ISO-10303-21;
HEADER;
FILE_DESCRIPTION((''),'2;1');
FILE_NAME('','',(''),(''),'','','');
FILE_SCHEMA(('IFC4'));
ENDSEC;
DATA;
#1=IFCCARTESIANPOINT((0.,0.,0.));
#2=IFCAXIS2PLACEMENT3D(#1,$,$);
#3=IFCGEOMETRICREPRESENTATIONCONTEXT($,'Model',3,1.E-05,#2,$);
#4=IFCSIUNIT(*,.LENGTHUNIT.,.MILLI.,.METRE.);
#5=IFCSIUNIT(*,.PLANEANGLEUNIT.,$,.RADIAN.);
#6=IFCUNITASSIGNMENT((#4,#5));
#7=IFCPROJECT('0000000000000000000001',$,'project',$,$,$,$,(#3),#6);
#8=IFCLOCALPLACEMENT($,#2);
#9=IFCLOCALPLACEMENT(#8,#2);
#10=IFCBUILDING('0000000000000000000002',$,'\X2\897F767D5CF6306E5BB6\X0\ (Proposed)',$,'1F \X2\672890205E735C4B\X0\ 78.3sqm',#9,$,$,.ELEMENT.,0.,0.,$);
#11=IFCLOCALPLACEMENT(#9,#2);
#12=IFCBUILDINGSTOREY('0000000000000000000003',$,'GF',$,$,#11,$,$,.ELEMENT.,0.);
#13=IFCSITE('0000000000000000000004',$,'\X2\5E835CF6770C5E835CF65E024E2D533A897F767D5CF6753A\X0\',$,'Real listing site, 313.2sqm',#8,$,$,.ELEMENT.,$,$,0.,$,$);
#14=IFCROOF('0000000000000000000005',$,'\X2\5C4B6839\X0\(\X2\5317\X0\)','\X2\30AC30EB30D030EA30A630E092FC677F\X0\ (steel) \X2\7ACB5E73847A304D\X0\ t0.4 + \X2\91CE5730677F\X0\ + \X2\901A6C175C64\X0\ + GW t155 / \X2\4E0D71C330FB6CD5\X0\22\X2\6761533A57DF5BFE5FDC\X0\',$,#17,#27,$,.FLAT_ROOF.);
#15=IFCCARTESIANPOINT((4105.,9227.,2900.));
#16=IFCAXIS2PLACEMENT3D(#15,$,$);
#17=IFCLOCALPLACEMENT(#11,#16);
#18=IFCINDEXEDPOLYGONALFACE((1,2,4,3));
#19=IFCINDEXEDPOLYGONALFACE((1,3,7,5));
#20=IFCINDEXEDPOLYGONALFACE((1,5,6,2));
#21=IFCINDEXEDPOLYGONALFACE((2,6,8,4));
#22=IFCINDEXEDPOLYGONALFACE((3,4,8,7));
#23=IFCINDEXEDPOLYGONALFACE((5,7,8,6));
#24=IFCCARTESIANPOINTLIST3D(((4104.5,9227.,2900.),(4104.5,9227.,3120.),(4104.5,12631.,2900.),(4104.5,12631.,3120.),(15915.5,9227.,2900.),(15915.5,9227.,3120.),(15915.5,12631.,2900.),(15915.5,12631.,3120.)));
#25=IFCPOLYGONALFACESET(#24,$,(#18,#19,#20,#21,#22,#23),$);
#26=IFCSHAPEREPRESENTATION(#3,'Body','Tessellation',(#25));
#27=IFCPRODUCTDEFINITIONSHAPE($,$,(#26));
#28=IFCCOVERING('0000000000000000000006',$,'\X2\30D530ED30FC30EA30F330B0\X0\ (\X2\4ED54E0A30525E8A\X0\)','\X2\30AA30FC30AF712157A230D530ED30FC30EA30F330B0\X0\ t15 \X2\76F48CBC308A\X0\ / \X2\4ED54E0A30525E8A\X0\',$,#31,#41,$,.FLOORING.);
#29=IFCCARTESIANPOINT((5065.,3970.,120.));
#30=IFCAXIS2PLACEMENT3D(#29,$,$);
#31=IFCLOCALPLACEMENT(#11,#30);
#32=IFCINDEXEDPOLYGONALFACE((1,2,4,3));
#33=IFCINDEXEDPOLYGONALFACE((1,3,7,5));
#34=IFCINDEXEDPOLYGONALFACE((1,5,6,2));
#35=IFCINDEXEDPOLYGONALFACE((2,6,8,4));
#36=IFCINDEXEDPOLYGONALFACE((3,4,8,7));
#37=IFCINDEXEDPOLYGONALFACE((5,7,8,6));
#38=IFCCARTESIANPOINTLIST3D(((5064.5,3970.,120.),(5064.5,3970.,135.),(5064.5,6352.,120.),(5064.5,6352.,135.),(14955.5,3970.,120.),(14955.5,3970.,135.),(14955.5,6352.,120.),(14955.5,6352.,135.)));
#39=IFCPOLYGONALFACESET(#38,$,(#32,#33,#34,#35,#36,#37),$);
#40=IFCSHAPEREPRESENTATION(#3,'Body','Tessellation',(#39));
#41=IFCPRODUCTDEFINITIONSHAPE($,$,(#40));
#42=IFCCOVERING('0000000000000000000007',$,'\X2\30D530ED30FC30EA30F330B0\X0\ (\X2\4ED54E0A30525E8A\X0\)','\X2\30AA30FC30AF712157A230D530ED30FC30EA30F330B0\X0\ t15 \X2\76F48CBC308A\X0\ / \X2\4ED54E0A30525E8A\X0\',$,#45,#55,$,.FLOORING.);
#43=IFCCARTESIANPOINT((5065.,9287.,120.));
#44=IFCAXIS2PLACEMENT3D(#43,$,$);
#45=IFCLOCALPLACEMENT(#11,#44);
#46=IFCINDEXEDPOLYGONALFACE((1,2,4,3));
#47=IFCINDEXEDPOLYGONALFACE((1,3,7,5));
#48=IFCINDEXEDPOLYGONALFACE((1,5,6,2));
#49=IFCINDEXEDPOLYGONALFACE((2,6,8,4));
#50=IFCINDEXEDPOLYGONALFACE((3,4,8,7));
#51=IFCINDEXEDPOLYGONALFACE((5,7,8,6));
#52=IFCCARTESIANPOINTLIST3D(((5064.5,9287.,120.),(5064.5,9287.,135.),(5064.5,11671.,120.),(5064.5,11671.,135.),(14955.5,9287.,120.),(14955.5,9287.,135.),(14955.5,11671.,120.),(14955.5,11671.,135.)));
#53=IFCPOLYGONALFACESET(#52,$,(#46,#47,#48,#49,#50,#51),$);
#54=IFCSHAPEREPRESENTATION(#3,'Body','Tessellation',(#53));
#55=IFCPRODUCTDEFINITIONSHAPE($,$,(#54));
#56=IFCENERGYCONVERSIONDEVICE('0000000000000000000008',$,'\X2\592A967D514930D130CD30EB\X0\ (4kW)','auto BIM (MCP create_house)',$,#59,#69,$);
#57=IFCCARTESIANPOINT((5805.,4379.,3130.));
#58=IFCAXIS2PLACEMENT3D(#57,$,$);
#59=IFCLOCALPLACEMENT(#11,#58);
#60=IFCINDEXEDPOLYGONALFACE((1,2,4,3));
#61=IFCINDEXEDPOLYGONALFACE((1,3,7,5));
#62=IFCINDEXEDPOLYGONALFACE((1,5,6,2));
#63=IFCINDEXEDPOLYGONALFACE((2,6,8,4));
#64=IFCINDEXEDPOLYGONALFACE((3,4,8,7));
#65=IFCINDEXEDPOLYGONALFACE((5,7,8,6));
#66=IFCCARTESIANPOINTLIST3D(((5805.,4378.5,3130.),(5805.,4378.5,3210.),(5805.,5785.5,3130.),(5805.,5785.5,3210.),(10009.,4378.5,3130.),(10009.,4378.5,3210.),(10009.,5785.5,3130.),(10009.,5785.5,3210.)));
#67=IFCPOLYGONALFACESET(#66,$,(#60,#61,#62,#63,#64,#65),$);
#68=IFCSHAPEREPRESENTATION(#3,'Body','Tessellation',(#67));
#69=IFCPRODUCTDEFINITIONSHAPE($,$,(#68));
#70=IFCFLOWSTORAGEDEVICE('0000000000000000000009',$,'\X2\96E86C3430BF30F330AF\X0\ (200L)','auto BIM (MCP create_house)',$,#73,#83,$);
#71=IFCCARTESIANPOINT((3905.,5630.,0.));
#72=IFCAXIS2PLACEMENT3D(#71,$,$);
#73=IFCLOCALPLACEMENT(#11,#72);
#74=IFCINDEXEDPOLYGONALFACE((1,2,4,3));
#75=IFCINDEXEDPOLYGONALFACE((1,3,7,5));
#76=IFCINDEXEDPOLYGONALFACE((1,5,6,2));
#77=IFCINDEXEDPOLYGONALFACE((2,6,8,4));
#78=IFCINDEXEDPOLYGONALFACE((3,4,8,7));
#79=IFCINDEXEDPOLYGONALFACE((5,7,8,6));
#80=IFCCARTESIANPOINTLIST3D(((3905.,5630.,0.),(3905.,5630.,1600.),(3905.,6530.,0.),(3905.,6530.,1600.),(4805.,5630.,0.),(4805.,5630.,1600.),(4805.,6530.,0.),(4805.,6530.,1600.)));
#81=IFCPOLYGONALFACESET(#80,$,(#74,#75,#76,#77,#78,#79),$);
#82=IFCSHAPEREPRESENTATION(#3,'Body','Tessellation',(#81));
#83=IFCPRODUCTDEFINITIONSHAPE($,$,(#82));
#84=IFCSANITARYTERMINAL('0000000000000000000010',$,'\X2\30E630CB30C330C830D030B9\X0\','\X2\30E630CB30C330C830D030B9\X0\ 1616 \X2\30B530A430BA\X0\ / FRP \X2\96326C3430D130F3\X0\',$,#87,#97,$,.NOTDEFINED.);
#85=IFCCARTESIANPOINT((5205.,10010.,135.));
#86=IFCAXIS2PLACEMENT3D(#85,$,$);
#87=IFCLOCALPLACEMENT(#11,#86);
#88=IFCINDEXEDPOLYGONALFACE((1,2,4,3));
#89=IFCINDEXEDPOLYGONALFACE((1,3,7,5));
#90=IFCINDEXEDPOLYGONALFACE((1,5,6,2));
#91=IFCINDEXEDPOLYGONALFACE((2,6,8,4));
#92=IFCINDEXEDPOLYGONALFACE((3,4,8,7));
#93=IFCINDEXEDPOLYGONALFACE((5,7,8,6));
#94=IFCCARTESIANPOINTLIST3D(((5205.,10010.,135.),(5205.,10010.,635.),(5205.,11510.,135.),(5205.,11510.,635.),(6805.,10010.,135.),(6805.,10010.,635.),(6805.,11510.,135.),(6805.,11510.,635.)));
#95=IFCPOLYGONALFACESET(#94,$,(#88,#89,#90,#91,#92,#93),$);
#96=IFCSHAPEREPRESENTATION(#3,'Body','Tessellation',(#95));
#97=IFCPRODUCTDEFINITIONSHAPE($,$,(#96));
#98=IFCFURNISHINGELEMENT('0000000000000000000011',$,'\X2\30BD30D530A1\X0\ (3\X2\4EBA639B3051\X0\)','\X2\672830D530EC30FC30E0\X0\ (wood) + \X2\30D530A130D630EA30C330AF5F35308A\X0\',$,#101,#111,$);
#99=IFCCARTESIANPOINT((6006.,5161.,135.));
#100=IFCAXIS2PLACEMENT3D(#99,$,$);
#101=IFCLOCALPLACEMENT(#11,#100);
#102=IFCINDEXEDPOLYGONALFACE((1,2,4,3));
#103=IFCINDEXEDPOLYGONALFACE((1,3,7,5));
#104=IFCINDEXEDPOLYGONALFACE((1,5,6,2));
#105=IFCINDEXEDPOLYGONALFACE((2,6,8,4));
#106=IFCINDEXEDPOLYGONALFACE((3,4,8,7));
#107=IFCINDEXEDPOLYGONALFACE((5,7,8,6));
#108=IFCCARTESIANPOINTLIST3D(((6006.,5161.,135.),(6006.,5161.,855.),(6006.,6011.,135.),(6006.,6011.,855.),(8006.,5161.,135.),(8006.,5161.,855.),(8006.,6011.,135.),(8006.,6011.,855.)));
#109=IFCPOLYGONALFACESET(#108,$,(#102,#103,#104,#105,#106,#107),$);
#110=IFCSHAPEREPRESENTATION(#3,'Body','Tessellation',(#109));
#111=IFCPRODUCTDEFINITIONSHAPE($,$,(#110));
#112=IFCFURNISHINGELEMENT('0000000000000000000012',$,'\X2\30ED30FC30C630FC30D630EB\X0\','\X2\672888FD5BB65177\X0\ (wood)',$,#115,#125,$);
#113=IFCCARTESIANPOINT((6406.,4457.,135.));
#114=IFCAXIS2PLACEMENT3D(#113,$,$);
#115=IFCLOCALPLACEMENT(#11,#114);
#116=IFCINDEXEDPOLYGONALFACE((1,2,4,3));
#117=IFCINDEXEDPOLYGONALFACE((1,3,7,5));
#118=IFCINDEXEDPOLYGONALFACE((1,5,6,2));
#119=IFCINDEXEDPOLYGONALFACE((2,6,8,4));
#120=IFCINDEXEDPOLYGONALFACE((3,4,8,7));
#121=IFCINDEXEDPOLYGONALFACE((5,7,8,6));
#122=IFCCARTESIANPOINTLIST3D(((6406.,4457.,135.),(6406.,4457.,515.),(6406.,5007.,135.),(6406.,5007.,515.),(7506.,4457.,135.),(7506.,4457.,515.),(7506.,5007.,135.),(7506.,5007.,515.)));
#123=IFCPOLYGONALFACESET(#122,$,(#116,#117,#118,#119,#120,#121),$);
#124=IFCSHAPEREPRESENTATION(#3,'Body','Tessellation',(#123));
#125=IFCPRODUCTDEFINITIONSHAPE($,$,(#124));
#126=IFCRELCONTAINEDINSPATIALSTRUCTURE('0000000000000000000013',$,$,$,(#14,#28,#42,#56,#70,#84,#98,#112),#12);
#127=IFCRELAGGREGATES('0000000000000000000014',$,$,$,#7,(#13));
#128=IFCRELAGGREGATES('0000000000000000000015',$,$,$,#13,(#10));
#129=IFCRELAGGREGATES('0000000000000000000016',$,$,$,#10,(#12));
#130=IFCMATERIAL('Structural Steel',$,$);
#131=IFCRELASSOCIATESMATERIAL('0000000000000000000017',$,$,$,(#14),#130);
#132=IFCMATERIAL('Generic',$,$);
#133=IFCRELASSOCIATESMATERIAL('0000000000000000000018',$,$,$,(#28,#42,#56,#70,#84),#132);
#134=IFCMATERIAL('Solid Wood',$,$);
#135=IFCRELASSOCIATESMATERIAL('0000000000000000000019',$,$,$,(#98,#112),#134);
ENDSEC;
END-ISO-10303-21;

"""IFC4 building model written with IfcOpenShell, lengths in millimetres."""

from ifc_helpers import new_model, si_unit, frame, frame_2d, origin, place, context, project, spatial, rectangle, extrude, material, element, save


model = new_model("IFC4")

# Units and contexts
model_context = context("Model", 3, precision=1e-05, world=origin())
ifc_project = project(units=[si_unit("LENGTHUNIT", "METRE", prefix="MILLI"), si_unit("PLANEANGLEUNIT", "RADIAN")], contexts=[model_context])

# Site, building, storey
site_placement = place(None, origin())
site = spatial("IfcSite", under=ifc_project, at=site_placement, Name="広島県広島市中区西白島町", ObjectType="Real listing site, 313.2sqm", CompositionType="ELEMENT", RefElevation=0.0)
building_placement = place(site_placement, origin())
building = spatial("IfcBuilding", under=site, at=building_placement, Name="西白島の家 (Proposed)", ObjectType="1F 木造平屋 78.3sqm", CompositionType="ELEMENT", ElevationOfRefHeight=0.0, ElevationOfTerrain=0.0)
storey_placement = place(building_placement, origin())
storey = spatial("IfcBuildingStorey", under=building, at=storey_placement, Name="GF", CompositionType="ELEMENT", Elevation=0.0)

# Shared definitions
ifc_material_1 = material(Name="Solid Wood")

# Roof
ifc_material_2 = material(Name="Structural Steel")
roof_1_placement = place(storey_placement, frame((4105.0, 9227.0, 2900.0)))
element("IfcRoof", 1, at=roof_1_placement, inside=storey, material=ifc_material_2, Name="屋根(北)", Description="ガルバリウム鋼板 (steel) 立平葺き t0.4 + 野地板 + 通気層 + GW t155 / 不燃・法22条区域対応", PredefinedType="FLAT_ROOF", context=model_context, shape_type="SweptSolid", body=[
    extrude(rectangle(XDim=11811.0, YDim=3404.0, at=frame_2d((5905.0, 1702.0))), frame((4105.0, 9227.0, 2900.0)), (0.0, 0.0, 1.0), 220.0),
])

# Coverings
ifc_material_3 = material(Name="Generic")
covering_1_placement = place(storey_placement, frame((5065.0, 3970.0, 120.0)))
element("IfcCovering", 2, at=covering_1_placement, inside=storey, material=ifc_material_3, Name="フローリング (仕上げ床)", Description="オーク無垢フローリング t15 直貼り / 仕上げ床", PredefinedType="FLOORING", context=model_context, shape_type="SweptSolid", body=[
    extrude(rectangle(XDim=9891.0, YDim=2382.0, at=frame_2d((4945.0, 1191.0))), frame((5065.0, 3970.0, 120.0)), (0.0, 0.0, 1.0), 15.0),
])
covering_2_placement = place(storey_placement, frame((5065.0, 9287.0, 120.0)))
element("IfcCovering", 3, at=covering_2_placement, inside=storey, material=ifc_material_3, Name="フローリング (仕上げ床)", Description="オーク無垢フローリング t15 直貼り / 仕上げ床", PredefinedType="FLOORING", context=model_context, shape_type="SweptSolid", body=[
    extrude(rectangle(XDim=9891.0, YDim=2384.0, at=frame_2d((4945.0, 1192.0))), frame((5065.0, 9287.0, 120.0)), (0.0, 0.0, 1.0), 15.0),
])

# Energy conversion device
energy_conversion_device_placement = place(storey_placement, frame((5805.0, 4379.0, 3130.0)))
element("IfcEnergyConversionDevice", 4, at=energy_conversion_device_placement, inside=storey, material=ifc_material_3, Name="太陽光パネル (4kW)", Description="auto BIM (MCP create_house)", context=model_context, shape_type="SweptSolid", body=[
    extrude(rectangle(XDim=4204.0, YDim=1407.0, at=frame_2d((2102.0, 703.0))), frame((5805.0, 4379.0, 3130.0)), (0.0, 0.0, 1.0), 80.0),
])

# Flow storage device
flow_storage_device_placement = place(storey_placement, frame((3905.0, 5630.0, 0.0)))
element("IfcFlowStorageDevice", 5, at=flow_storage_device_placement, inside=storey, material=ifc_material_3, Name="雨水タンク (200L)", Description="auto BIM (MCP create_house)", context=model_context, shape_type="SweptSolid", body=[
    extrude(rectangle(XDim=900.0, YDim=900.0, at=frame_2d((450.0, 450.0))), frame((3905.0, 5630.0, 0.0)), (0.0, 0.0, 1.0), 1600.0),
])

# Sanitary terminal
sanitary_terminal_placement = place(storey_placement, frame((5205.0, 10010.0, 135.0)))
element("IfcSanitaryTerminal", 6, at=sanitary_terminal_placement, inside=storey, material=ifc_material_3, Name="ユニットバス", Description="ユニットバス 1616 サイズ / FRP 防水パン", PredefinedType="NOTDEFINED", context=model_context, shape_type="SweptSolid", body=[
    extrude(rectangle(XDim=1600.0, YDim=1500.0, at=frame_2d((800.0, 750.0))), frame((5205.0, 10010.0, 135.0)), (0.0, 0.0, 1.0), 500.0),
])

# Furnishing elements
furnishing_1_placement = place(storey_placement, frame((6006.0, 5161.0, 135.0)))
element("IfcFurnishingElement", 7, at=furnishing_1_placement, inside=storey, material=ifc_material_1, Name="ソファ (3人掛け)", Description="木フレーム (wood) + ファブリック張り", context=model_context, shape_type="SweptSolid", body=[
    extrude(rectangle(XDim=2000.0, YDim=850.0, at=frame_2d((1000.0, 425.0))), frame((6006.0, 5161.0, 135.0)), (0.0, 0.0, 1.0), 720.0),
])
furnishing_2_placement = place(storey_placement, frame((6406.0, 4457.0, 135.0)))
element("IfcFurnishingElement", 8, at=furnishing_2_placement, inside=storey, material=ifc_material_1, Name="ローテーブル", Description="木製家具 (wood)", context=model_context, shape_type="SweptSolid", body=[
    extrude(rectangle(XDim=1100.0, YDim=550.0, at=frame_2d((550.0, 275.0))), frame((6406.0, 4457.0, 135.0)), (0.0, 0.0, 1.0), 380.0),
])

save(model, "model.ifc")
